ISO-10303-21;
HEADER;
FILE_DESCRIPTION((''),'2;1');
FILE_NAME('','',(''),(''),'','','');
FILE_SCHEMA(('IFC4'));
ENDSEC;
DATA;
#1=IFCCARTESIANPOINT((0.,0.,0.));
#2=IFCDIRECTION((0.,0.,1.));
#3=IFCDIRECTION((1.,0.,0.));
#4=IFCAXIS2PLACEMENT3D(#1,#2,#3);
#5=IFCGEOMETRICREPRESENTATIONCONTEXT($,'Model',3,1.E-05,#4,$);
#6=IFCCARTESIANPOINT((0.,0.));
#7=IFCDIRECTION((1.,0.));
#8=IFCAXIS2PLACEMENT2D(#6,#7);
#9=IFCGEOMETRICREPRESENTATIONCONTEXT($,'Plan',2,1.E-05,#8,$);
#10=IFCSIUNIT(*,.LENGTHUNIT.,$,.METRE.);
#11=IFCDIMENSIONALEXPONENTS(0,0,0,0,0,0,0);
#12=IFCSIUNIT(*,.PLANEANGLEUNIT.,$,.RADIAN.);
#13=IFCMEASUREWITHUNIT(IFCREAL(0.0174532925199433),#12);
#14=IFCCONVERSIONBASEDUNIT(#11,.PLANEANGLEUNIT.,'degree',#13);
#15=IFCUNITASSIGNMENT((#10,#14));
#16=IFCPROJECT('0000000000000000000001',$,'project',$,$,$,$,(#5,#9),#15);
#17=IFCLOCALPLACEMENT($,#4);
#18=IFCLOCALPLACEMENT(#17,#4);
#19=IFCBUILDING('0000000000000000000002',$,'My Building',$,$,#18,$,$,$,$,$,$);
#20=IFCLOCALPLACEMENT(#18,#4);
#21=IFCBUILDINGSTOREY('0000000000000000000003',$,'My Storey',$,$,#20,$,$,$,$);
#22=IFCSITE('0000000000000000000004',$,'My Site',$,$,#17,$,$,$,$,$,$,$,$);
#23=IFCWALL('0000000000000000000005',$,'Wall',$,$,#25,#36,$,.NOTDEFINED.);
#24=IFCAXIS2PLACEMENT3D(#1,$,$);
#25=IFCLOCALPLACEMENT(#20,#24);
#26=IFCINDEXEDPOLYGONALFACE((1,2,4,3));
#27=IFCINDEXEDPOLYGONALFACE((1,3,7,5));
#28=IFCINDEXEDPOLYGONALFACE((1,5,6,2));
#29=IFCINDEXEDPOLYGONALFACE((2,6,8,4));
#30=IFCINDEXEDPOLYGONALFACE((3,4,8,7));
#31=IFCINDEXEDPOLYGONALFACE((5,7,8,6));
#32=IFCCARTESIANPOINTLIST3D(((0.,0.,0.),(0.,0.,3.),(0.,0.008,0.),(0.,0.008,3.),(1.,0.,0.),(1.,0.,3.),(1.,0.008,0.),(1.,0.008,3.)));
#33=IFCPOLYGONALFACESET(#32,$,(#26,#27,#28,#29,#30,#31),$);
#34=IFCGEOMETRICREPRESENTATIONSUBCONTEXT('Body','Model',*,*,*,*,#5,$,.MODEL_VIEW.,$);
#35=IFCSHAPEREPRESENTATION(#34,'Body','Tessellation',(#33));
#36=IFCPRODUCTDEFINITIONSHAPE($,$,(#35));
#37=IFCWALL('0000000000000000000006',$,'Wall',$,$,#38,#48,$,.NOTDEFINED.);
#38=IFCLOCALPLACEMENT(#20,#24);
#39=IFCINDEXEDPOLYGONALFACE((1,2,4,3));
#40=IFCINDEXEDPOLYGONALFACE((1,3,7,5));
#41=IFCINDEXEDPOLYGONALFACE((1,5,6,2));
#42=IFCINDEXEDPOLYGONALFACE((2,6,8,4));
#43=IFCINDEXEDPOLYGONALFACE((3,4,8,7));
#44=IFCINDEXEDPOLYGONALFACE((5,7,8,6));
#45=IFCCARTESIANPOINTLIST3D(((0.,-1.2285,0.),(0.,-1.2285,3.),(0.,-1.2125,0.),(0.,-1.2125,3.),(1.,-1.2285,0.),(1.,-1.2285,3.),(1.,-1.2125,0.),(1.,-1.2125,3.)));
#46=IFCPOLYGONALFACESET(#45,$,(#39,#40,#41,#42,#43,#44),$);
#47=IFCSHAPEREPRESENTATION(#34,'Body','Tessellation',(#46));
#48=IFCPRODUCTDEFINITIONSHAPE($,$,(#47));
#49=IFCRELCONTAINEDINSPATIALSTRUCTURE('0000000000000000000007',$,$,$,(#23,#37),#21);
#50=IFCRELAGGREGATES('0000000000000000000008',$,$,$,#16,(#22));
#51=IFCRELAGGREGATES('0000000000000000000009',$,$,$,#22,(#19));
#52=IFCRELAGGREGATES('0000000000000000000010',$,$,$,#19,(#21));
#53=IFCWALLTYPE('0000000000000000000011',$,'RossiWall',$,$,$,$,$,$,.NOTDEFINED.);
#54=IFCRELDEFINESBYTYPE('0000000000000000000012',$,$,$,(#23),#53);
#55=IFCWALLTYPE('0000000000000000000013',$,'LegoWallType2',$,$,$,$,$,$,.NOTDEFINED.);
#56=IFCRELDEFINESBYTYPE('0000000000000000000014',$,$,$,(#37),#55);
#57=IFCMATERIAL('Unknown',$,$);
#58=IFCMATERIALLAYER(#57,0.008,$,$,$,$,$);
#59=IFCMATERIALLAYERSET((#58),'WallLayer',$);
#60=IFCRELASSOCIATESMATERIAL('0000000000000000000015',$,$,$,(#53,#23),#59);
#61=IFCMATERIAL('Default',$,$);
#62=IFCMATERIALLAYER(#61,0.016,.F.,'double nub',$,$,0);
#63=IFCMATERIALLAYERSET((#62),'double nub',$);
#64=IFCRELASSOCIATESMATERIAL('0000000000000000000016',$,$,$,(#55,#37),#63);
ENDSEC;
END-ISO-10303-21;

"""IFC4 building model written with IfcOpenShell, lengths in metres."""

from ifc_helpers import new_model, entity, si_unit, converted_unit, frame, origin_with_axes, origin_2d_with_axis, place, context, subcontext, project, spatial, indexed_curve, outline, extrude, material, layer, layer_set, layer_usage, type_object, element, save


model = new_model("IFC4")

# Units and contexts
model_context = context("Model", 3, precision=1e-05, world=origin_with_axes())
plan_context = context("Plan", 2, precision=1e-05, world=origin_2d_with_axis())
body_context = subcontext(model_context, "Body", "Model", "MODEL_VIEW")
ifc_project = project(units=[si_unit("LENGTHUNIT", "METRE"), converted_unit("PLANEANGLEUNIT", "degree", entity("IfcReal", 0.0174532925199433), si_unit("PLANEANGLEUNIT", "RADIAN"), dimensions=[0, 0, 0, 0, 0, 0, 0])], contexts=[model_context, plan_context])

# Site, building, storey
site_placement = place(None, origin_with_axes())
site = spatial("IfcSite", under=ifc_project, at=site_placement, Name="My Site")
building_placement = place(site_placement, origin_with_axes())
building = spatial("IfcBuilding", under=site, at=building_placement, Name="My Building")
storey_placement = place(building_placement, origin_with_axes())
storey = spatial("IfcBuildingStorey", under=building, at=storey_placement, Name="My Storey")

# Walls
ifc_material_1 = material(Name="Unknown")
ifc_layer_1 = layer(ifc_material_1, 0.008)
ifc_layer_set_1 = layer_set([ifc_layer_1], Name="WallLayer")
ifc_layer_usage_1 = layer_usage(ifc_layer_set_1, "AXIS2", "POSITIVE", 0.0)
wall_type_1 = type_object("IfcWallType", Name="RossiWall", PredefinedType="NOTDEFINED", material=ifc_layer_set_1)
wall_1_placement = place(storey_placement, origin_with_axes())
element("IfcWall", 1, at=wall_1_placement, inside=storey, type_object=wall_type_1, material=ifc_layer_usage_1, Name="Wall", PredefinedType="NOTDEFINED", context=body_context, shape_type="SweptSolid", body=[
    extrude(outline(indexed_curve([(0.0, 0.0), (0.0, 0.008), (1.0, 0.008), (1.0, 0.0), (0.0, 0.0)], self_intersect=False)), origin_with_axes(), (0.0, 0.0, 1.0), 3.0),
])
ifc_material_2 = material(Name="Default")
ifc_layer_2 = layer(ifc_material_2, 0.016, ventilated=False, Name="double nub", Priority=0)
ifc_layer_set_2 = layer_set([ifc_layer_2], Name="double nub")
ifc_layer_usage_2 = layer_usage(ifc_layer_set_2, "AXIS2", "POSITIVE", 0.0)
wall_type_2 = type_object("IfcWallType", Name="LegoWallType2", PredefinedType="NOTDEFINED", material=ifc_layer_set_2)
wall_2_placement = place(storey_placement, frame((0.0, -1.2285, 0.0), z_axis=(0.0, 0.0, 1.0), x_axis=(1.0, 0.0, 0.0)))
element("IfcWall", 2, at=wall_2_placement, inside=storey, type_object=wall_type_2, material=ifc_layer_usage_2, Name="Wall", PredefinedType="NOTDEFINED", context=body_context, shape_type="SweptSolid", body=[
    extrude(outline(indexed_curve([(0.0, 0.0), (0.0, 0.016), (1.0, 0.016), (1.0, 0.0), (0.0, 0.0)], self_intersect=False)), origin_with_axes(), (0.0, 0.0, 1.0), 3.0),
])

save(model, "model.ifc")
